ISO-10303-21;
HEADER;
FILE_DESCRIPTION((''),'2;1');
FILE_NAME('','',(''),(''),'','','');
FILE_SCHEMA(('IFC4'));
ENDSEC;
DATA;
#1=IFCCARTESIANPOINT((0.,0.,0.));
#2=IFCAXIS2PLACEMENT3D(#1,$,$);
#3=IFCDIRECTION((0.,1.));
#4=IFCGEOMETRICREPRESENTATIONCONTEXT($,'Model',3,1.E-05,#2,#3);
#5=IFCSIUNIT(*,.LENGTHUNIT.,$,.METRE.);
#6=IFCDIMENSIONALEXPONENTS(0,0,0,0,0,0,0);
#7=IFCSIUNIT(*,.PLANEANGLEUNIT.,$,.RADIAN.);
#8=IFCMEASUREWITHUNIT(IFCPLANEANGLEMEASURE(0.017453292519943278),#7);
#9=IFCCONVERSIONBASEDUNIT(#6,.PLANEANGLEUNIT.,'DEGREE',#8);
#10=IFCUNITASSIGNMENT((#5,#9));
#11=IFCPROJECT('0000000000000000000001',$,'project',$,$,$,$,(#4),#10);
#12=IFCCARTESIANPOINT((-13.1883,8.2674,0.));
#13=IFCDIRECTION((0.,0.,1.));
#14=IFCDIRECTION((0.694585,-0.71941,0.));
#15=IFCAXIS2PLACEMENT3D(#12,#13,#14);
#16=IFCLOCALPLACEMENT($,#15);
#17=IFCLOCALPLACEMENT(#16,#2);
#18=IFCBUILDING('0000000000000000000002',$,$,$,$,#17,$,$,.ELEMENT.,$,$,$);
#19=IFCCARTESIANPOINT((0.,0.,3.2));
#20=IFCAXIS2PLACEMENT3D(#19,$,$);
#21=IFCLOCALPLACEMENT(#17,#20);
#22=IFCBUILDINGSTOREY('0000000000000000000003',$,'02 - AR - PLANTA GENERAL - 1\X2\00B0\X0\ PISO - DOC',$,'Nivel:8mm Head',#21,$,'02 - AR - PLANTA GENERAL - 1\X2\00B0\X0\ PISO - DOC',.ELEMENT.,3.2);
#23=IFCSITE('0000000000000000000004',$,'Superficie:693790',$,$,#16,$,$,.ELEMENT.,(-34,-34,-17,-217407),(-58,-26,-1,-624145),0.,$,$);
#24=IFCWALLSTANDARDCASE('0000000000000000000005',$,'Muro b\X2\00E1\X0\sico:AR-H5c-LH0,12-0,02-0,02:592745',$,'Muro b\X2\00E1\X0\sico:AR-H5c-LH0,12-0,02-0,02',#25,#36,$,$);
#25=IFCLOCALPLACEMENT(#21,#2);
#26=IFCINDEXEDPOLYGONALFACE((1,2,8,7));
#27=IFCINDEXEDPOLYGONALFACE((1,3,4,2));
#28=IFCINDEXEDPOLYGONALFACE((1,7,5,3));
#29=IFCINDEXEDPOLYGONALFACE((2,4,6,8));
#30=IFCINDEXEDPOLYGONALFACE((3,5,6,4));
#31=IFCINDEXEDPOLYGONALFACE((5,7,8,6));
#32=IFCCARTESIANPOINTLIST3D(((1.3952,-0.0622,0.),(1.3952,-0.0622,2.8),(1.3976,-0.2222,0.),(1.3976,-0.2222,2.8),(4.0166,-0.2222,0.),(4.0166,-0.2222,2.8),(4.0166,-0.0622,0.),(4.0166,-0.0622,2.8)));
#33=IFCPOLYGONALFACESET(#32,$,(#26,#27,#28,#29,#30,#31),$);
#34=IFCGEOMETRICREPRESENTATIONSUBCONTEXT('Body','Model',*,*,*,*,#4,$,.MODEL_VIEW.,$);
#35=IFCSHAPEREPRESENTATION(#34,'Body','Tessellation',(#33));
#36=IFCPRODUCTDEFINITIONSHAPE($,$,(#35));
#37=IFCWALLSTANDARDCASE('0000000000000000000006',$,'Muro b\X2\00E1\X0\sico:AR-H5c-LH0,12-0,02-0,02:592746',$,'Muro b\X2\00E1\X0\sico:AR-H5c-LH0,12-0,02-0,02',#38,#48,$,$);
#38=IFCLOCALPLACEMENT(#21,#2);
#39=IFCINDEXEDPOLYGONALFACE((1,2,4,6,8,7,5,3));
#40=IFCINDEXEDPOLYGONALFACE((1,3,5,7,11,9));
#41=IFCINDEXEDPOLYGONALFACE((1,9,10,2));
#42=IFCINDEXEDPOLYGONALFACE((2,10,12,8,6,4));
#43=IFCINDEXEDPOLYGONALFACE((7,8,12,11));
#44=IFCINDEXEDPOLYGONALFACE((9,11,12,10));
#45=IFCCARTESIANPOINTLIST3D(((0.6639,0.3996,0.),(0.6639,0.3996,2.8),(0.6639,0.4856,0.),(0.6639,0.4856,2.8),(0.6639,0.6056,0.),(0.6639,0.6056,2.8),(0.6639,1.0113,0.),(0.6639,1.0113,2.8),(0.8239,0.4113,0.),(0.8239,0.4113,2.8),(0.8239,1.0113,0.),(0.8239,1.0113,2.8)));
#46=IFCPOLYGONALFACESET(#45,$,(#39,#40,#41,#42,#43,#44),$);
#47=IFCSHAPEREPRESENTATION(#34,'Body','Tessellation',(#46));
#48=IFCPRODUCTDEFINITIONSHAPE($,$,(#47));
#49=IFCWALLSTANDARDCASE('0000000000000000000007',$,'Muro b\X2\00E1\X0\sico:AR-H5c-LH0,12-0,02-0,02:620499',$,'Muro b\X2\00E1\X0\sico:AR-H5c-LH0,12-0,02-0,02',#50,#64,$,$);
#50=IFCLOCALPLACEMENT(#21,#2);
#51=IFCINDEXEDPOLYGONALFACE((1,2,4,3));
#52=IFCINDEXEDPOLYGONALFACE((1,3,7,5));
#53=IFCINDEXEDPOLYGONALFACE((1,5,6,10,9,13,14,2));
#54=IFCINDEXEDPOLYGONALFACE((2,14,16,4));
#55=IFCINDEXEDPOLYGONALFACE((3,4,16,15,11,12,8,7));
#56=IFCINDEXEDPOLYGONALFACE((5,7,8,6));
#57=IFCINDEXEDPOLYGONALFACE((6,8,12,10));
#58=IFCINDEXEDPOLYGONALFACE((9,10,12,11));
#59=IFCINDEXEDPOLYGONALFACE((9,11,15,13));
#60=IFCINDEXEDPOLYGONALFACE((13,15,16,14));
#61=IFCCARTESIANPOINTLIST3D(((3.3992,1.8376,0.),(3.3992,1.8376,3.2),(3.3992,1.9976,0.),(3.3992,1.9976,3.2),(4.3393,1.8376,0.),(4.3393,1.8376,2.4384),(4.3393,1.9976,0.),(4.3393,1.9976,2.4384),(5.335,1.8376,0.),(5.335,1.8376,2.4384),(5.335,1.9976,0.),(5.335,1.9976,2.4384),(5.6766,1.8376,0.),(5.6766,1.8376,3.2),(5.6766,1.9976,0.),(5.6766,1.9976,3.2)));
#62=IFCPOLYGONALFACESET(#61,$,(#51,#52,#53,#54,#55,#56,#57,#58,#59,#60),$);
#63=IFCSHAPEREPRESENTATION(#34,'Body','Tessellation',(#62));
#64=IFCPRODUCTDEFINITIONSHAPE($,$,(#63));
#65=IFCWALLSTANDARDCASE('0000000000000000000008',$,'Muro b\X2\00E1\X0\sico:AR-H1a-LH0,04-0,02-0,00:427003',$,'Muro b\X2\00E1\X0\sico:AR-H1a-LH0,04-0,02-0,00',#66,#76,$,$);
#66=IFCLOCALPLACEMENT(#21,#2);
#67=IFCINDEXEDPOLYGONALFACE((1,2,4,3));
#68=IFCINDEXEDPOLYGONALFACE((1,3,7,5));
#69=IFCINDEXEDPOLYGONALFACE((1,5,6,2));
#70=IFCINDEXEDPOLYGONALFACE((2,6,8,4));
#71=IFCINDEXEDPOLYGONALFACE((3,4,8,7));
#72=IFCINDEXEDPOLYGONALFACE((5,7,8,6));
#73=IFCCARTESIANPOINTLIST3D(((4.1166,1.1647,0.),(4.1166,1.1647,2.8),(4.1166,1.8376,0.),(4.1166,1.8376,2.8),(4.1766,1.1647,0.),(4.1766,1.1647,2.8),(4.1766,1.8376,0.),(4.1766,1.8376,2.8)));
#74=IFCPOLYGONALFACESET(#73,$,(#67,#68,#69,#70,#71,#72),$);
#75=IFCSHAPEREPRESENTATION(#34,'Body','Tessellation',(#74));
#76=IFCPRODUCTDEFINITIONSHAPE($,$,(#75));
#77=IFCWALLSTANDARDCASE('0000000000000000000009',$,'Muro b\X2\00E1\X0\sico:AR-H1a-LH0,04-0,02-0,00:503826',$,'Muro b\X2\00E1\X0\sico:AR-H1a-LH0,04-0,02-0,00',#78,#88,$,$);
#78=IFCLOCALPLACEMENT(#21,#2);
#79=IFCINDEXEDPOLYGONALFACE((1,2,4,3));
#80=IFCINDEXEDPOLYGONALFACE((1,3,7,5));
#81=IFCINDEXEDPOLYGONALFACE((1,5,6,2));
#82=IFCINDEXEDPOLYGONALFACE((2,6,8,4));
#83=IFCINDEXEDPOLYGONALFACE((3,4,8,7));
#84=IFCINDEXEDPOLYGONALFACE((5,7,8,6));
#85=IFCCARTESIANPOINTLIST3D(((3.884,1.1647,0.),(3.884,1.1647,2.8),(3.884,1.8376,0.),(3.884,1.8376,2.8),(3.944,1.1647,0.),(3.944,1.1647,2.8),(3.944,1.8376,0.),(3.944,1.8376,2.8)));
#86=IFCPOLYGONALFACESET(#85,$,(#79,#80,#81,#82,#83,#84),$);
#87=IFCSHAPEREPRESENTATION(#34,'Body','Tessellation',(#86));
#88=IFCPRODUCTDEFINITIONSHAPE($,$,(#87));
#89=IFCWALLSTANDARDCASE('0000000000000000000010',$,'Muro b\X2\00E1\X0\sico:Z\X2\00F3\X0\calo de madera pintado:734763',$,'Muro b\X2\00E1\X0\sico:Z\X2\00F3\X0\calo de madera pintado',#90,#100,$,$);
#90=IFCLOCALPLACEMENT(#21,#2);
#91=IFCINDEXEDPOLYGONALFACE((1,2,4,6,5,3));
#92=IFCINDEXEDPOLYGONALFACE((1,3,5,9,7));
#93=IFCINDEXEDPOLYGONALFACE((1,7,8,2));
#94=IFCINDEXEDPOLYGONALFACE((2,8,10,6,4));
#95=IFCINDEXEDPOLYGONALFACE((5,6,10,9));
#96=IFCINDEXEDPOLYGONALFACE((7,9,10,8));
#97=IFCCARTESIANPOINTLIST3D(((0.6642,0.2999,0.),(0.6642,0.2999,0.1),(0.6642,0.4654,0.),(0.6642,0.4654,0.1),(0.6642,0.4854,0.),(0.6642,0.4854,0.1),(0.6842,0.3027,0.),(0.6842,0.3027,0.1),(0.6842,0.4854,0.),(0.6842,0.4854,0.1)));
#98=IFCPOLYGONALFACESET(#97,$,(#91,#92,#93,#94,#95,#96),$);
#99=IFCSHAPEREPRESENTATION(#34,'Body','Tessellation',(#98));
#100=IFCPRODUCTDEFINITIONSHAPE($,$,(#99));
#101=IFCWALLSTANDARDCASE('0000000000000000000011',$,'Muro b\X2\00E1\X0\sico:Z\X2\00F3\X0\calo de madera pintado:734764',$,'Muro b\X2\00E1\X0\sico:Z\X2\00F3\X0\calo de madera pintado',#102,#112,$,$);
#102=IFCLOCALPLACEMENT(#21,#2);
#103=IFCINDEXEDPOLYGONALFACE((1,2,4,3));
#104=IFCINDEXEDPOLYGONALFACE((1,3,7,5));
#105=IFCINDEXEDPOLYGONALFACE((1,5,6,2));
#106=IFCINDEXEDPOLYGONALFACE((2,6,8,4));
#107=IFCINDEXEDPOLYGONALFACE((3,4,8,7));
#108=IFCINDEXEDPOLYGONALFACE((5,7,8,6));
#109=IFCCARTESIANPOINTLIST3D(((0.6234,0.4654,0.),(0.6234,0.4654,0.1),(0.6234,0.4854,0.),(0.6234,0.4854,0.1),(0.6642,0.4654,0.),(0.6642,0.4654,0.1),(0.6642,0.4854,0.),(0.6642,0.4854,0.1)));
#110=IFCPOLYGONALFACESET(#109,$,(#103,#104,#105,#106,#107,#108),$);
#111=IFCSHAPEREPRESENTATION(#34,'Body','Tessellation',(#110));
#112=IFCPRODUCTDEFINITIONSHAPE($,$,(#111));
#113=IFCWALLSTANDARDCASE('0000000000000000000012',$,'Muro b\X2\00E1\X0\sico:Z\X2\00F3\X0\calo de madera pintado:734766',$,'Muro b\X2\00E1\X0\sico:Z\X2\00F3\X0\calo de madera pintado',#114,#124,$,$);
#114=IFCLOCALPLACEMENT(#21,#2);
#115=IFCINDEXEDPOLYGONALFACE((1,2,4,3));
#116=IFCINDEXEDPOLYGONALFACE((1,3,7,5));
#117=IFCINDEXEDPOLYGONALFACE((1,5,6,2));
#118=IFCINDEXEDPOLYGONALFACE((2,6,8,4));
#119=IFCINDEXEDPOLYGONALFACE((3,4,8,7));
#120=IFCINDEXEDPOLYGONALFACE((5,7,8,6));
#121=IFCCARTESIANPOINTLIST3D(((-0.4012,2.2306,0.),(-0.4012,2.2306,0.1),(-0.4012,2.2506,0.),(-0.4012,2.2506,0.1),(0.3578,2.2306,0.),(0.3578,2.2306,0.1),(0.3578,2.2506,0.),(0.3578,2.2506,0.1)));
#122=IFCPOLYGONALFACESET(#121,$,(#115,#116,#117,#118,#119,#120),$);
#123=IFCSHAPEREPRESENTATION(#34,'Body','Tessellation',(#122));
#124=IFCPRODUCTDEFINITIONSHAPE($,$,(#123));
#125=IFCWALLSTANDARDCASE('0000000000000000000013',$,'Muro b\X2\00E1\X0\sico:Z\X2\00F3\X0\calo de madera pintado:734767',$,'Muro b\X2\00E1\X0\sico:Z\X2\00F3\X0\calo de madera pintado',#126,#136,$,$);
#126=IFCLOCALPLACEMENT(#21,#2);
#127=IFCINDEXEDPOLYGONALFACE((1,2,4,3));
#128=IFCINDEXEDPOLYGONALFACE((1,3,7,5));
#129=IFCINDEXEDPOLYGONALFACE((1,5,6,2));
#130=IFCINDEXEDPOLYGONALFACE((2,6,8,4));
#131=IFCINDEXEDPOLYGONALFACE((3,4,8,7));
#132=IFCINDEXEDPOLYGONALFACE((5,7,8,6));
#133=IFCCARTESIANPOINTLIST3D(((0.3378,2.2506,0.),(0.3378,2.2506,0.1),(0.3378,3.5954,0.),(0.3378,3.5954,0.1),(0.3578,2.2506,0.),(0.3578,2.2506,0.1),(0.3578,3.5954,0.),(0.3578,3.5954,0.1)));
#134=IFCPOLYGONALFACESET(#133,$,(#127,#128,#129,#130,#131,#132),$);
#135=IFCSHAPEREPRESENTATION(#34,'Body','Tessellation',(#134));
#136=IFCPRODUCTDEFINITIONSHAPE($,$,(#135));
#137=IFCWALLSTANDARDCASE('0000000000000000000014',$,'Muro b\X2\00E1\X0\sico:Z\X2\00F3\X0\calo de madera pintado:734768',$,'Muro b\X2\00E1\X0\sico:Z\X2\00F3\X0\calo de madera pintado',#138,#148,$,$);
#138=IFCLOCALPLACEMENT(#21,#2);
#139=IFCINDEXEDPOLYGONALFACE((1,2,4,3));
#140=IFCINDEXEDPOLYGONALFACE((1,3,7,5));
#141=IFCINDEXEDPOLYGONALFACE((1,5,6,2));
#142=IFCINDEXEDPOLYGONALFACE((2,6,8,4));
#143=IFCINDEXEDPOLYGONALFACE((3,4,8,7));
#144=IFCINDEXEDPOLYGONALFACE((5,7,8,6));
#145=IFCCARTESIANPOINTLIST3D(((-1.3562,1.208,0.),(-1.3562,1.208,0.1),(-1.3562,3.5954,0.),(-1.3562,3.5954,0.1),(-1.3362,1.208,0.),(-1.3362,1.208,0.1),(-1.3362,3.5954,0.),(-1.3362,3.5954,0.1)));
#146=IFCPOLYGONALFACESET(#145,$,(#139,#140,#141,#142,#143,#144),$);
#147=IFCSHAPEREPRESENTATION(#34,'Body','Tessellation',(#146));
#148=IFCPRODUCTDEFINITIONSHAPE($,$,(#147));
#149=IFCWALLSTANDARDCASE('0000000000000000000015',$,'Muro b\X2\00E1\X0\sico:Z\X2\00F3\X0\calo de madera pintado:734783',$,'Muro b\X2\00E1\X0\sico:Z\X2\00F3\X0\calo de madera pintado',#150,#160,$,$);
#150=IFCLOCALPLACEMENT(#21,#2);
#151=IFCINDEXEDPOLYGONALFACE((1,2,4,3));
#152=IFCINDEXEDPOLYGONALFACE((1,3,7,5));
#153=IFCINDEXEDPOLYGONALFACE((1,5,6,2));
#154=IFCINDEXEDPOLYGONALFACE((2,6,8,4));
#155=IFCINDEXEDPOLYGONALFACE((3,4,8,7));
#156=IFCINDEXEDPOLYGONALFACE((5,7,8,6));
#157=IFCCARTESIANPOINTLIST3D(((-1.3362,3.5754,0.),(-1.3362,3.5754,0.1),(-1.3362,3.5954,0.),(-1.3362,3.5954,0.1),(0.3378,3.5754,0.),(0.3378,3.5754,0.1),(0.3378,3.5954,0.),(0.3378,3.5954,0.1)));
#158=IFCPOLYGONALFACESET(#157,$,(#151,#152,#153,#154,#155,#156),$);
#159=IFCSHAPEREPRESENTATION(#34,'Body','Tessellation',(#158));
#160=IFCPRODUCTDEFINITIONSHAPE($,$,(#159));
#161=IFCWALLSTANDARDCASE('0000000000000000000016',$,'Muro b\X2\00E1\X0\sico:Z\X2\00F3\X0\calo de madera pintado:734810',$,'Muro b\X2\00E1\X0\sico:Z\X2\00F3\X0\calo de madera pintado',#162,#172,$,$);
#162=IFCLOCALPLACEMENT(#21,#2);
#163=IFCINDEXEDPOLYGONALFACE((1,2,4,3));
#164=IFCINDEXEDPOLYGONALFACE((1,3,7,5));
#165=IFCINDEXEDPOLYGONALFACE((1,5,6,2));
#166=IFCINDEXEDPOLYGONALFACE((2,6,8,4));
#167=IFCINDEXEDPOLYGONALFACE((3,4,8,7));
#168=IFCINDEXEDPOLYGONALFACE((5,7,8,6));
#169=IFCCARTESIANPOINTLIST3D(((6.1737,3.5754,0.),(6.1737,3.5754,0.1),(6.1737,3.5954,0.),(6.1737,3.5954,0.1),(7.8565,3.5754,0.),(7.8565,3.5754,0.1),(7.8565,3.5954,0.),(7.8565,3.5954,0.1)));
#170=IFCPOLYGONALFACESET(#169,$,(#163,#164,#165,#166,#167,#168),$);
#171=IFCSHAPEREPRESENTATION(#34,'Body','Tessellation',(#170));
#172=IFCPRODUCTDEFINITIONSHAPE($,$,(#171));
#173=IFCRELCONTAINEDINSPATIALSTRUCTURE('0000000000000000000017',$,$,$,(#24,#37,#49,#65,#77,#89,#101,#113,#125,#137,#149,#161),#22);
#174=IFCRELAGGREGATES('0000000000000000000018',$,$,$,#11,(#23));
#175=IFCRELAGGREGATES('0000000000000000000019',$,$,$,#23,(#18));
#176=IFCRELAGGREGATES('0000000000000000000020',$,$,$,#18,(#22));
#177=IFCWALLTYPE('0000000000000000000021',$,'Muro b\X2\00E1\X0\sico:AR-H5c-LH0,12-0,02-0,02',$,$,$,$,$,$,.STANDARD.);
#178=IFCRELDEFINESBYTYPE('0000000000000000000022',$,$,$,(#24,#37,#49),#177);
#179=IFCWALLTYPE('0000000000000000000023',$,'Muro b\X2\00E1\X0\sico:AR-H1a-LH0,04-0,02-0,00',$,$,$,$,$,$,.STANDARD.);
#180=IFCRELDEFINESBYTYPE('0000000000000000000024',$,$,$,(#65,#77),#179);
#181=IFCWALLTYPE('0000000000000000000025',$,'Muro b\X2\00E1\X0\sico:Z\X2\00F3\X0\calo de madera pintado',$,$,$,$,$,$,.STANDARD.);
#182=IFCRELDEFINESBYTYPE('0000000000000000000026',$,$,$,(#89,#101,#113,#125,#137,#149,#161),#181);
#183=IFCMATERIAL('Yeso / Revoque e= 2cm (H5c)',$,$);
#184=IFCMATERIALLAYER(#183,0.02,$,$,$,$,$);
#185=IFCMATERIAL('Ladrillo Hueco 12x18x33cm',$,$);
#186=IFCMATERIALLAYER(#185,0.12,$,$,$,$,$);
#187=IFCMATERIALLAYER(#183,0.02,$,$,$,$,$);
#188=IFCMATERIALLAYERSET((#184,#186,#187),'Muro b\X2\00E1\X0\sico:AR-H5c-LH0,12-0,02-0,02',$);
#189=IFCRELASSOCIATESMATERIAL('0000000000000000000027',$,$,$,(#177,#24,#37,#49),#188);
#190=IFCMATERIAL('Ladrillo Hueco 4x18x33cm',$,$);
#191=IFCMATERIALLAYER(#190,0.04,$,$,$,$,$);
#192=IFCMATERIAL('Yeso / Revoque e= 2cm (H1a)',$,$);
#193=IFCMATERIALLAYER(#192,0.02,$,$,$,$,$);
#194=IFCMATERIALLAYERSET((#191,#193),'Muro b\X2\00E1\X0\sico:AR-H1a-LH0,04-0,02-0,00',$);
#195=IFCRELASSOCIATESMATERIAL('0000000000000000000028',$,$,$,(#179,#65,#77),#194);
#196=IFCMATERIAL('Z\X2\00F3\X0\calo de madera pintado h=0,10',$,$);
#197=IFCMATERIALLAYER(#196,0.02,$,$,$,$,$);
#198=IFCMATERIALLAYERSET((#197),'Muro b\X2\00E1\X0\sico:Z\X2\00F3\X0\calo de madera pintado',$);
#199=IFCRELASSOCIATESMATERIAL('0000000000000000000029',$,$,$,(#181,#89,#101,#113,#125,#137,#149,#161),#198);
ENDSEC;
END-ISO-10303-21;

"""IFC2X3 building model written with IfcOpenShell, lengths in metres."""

from ifc_helpers import new_model, entity, si_unit, converted_unit, direction, frame, frame_2d, origin, place, context, subcontext, project, spatial, polyline, rectangle, outline, extrude, material, layer, layer_set, layer_usage, type_object, element, save


model = new_model("IFC2X3")

# Units and contexts
model_context = context("Model", 3, precision=1e-05, world=origin(), true_north=direction((0.0, 1.0)))
body_context = subcontext(model_context, "Body", "Model", "MODEL_VIEW")
ifc_project = project(units=[si_unit("LENGTHUNIT", "METRE"), converted_unit("PLANEANGLEUNIT", "DEGREE", entity("IfcPlaneAngleMeasure", 0.017453292519943278), si_unit("PLANEANGLEUNIT", "RADIAN"), dimensions=[0, 0, 0, 0, 0, 0, 0])], contexts=[model_context])

# Site, building, storey
site_placement = place(None, frame((-13.1883, 8.2674, 0.0), z_axis=(0.0, 0.0, 1.0), x_axis=(0.694585, -0.71941, 0.0)))
site = spatial("IfcSite", under=ifc_project, at=site_placement, Name="Superficie:693790", CompositionType="ELEMENT", RefLatitude=(-34, -34, -17, -217407), RefLongitude=(-58, -26, -1, -624145), RefElevation=0.0)
building_placement = place(site_placement, origin())
building = spatial("IfcBuilding", under=site, at=building_placement, CompositionType="ELEMENT")
storey_placement = place(building_placement, frame((0.0, 0.0, 3.2)))
storey = spatial("IfcBuildingStorey", under=building, at=storey_placement, Name="02 - AR - PLANTA GENERAL - 1° PISO - DOC", ObjectType="Nivel:8mm Head", LongName="02 - AR - PLANTA GENERAL - 1° PISO - DOC", CompositionType="ELEMENT", Elevation=3.2)

# Walls
ifc_material_1 = material(Name="Yeso / Revoque e= 2cm (H5c)")
ifc_layer_1 = layer(ifc_material_1, 0.02)
ifc_material_2 = material(Name="Ladrillo Hueco 12x18x33cm")
ifc_layer_2 = layer(ifc_material_2, 0.12)
ifc_layer_3 = layer(ifc_material_1, 0.02)
ifc_layer_set_1 = layer_set([ifc_layer_1, ifc_layer_2, ifc_layer_3], Name="Muro básico:AR-H5c-LH0,12-0,02-0,02")
ifc_layer_usage_1 = layer_usage(ifc_layer_set_1, "AXIS2", "NEGATIVE", 0.08)
wall_type_1 = type_object("IfcWallType", Name="Muro básico:AR-H5c-LH0,12-0,02-0,02", PredefinedType="STANDARD", material=ifc_layer_set_1)
wall_1_placement = place(storey_placement, frame((1.3952, -0.1422, 0.0)))
element("IfcWallStandardCase", 1, at=wall_1_placement, inside=storey, type_object=wall_type_1, material=ifc_layer_usage_1, Name="Muro básico:AR-H5c-LH0,12-0,02-0,02:592745", ObjectType="Muro básico:AR-H5c-LH0,12-0,02-0,02", context=body_context, shape_type="SweptSolid", body=[
    extrude(outline(polyline([(2.6214, -0.08), (2.6214, 0.08), (0.0, 0.08), (0.0024, -0.08), (2.6214, -0.08)])), origin(), (0.0, 0.0, 1.0), 2.8),
])
ifc_layer_usage_2 = layer_usage(ifc_layer_set_1, "AXIS2", "NEGATIVE", 0.08)
wall_2_placement = place(storey_placement, frame((0.7439, 0.3996, 0.0), z_axis=(0.0, 0.0, 1.0), x_axis=(0.0, 1.0, 0.0)))
element("IfcWallStandardCase", 2, at=wall_2_placement, inside=storey, type_object=wall_type_1, material=ifc_layer_usage_2, Name="Muro básico:AR-H5c-LH0,12-0,02-0,02:592746", ObjectType="Muro básico:AR-H5c-LH0,12-0,02-0,02", context=body_context, shape_type="SweptSolid", body=[
    extrude(outline(polyline([(0.6117, -0.08), (0.6117, 0.08), (0.2059, 0.08), (0.0859, 0.08), (0.0, 0.08), (0.0117, -0.08), (0.6117, -0.08)])), origin(), (0.0, 0.0, 1.0), 2.8),
])

# Wall, opening
ifc_layer_usage_3 = layer_usage(ifc_layer_set_1, "AXIS2", "NEGATIVE", 0.08)
wall_3_placement = place(storey_placement, frame((5.6766, 1.9176, 0.0), z_axis=(0.0, 0.0, 1.0), x_axis=(-1.0, 0.0, 0.0)))
wall_3 = element("IfcWallStandardCase", 3, at=wall_3_placement, inside=storey, type_object=wall_type_1, material=ifc_layer_usage_3, Name="Muro básico:AR-H5c-LH0,12-0,02-0,02:620499", ObjectType="Muro básico:AR-H5c-LH0,12-0,02-0,02", context=body_context, shape_type="SweptSolid", body=[
    extrude(rectangle(XDim=2.2775, YDim=0.16, at=frame_2d((1.1387, 0.0), x_axis=(1.0, 0.0))), origin(), (0.0, 0.0, 1.0), 3.2),
])
opening_1_placement = place(wall_3_placement, origin())
element("IfcOpeningElement", 4, at=opening_1_placement, cuts=wall_3, ObjectType="Opening", context=body_context, shape_type="SweptSolid", body=[
    extrude(rectangle(XDim=2.4384, YDim=0.9958, at=frame_2d((0.0, 0.0), x_axis=(1.0, 0.0))), frame((0.8395, -0.08, 1.2192), z_axis=(0.0, 1.0, 0.0), x_axis=(0.0, 0.0, -1.0)), (0.0, 0.0, 1.0), 0.16),
])

# Walls
ifc_material_3 = material(Name="Ladrillo Hueco 4x18x33cm")
ifc_layer_4 = layer(ifc_material_3, 0.04)
ifc_material_4 = material(Name="Yeso / Revoque e= 2cm (H1a)")
ifc_layer_5 = layer(ifc_material_4, 0.02)
ifc_layer_set_2 = layer_set([ifc_layer_4, ifc_layer_5], Name="Muro básico:AR-H1a-LH0,04-0,02-0,00")
ifc_layer_usage_4 = layer_usage(ifc_layer_set_2, "AXIS2", "POSITIVE", -0.03)
wall_type_2 = type_object("IfcWallType", Name="Muro básico:AR-H1a-LH0,04-0,02-0,00", PredefinedType="STANDARD", material=ifc_layer_set_2)
wall_4_placement = place(storey_placement, frame((4.1466, 1.8376, 0.0), z_axis=(0.0, 0.0, 1.0), x_axis=(0.0, -1.0, 0.0)))
element("IfcWallStandardCase", 5, at=wall_4_placement, inside=storey, type_object=wall_type_2, material=ifc_layer_usage_4, Name="Muro básico:AR-H1a-LH0,04-0,02-0,00:427003", ObjectType="Muro básico:AR-H1a-LH0,04-0,02-0,00", context=body_context, shape_type="SweptSolid", body=[
    extrude(rectangle(XDim=0.673, YDim=0.06, at=frame_2d((0.3365, 0.0), x_axis=(-1.0, 0.0))), origin(), (0.0, 0.0, 1.0), 2.8),
])
ifc_layer_usage_5 = layer_usage(ifc_layer_set_2, "AXIS2", "POSITIVE", -0.03)
wall_5_placement = place(storey_placement, frame((3.914, 1.8376, 0.0), z_axis=(0.0, 0.0, 1.0), x_axis=(0.0, -1.0, 0.0)))
element("IfcWallStandardCase", 6, at=wall_5_placement, inside=storey, type_object=wall_type_2, material=ifc_layer_usage_5, Name="Muro básico:AR-H1a-LH0,04-0,02-0,00:503826", ObjectType="Muro básico:AR-H1a-LH0,04-0,02-0,00", context=body_context, shape_type="SweptSolid", body=[
    extrude(rectangle(XDim=0.673, YDim=0.06, at=frame_2d((0.3365, 0.0), x_axis=(-1.0, 0.0))), origin(), (0.0, 0.0, 1.0), 2.8),
])
ifc_material_5 = material(Name="Zócalo de madera pintado h=0,10")
ifc_layer_6 = layer(ifc_material_5, 0.02)
ifc_layer_set_3 = layer_set([ifc_layer_6], Name="Muro básico:Zócalo de madera pintado")
wall_type_3 = type_object("IfcWallType", Name="Muro básico:Zócalo de madera pintado", PredefinedType="STANDARD", material=ifc_layer_set_3)
ifc_layer_usage_6 = layer_usage(ifc_layer_set_3, "AXIS2", "NEGATIVE", 0.01)
wall_6_placement = place(storey_placement, frame((0.6742, 0.2999, 0.0), z_axis=(0.0, 0.0, 1.0), x_axis=(0.0, 1.0, 0.0)))
element("IfcWallStandardCase", 7, at=wall_6_placement, inside=storey, type_object=wall_type_3, material=ifc_layer_usage_6, Name="Muro básico:Zócalo de madera pintado:734763", ObjectType="Muro básico:Zócalo de madera pintado", context=body_context, shape_type="SweptSolid", body=[
    extrude(outline(polyline([(0.1855, -0.01), (0.1855, 0.01), (0.1655, 0.01), (0.0, 0.01), (0.0027, -0.01), (0.1855, -0.01)])), origin(), (0.0, 0.0, 1.0), 0.1),
])
ifc_layer_usage_7 = layer_usage(ifc_layer_set_3, "AXIS2", "NEGATIVE", 0.01)
wall_7_placement = place(storey_placement, frame((0.6642, 0.4754, 0.0), z_axis=(0.0, 0.0, 1.0), x_axis=(-1.0, 0.0, 0.0)))
element("IfcWallStandardCase", 8, at=wall_7_placement, inside=storey, type_object=wall_type_3, material=ifc_layer_usage_7, Name="Muro básico:Zócalo de madera pintado:734764", ObjectType="Muro básico:Zócalo de madera pintado", context=body_context, shape_type="SweptSolid", body=[
    extrude(rectangle(XDim=0.0408, YDim=0.02, at=frame_2d((0.0204, 0.0), x_axis=(-1.0, 0.0))), origin(), (0.0, 0.0, 1.0), 0.1),
])
ifc_layer_usage_8 = layer_usage(ifc_layer_set_3, "AXIS2", "NEGATIVE", 0.01)
wall_8_placement = place(storey_placement, frame((-0.4012, 2.2406, 0.0)))
element("IfcWallStandardCase", 9, at=wall_8_placement, inside=storey, type_object=wall_type_3, material=ifc_layer_usage_8, Name="Muro básico:Zócalo de madera pintado:734766", ObjectType="Muro básico:Zócalo de madera pintado", context=body_context, shape_type="SweptSolid", body=[
    extrude(rectangle(XDim=0.759, YDim=0.02, at=frame_2d((0.3795, 0.0), x_axis=(-1.0, 0.0))), origin(), (0.0, 0.0, 1.0), 0.1),
])
ifc_layer_usage_9 = layer_usage(ifc_layer_set_3, "AXIS2", "NEGATIVE", 0.01)
wall_9_placement = place(storey_placement, frame((0.3478, 2.2506, 0.0), z_axis=(0.0, 0.0, 1.0), x_axis=(0.0, 1.0, 0.0)))
element("IfcWallStandardCase", 10, at=wall_9_placement, inside=storey, type_object=wall_type_3, material=ifc_layer_usage_9, Name="Muro básico:Zócalo de madera pintado:734767", ObjectType="Muro básico:Zócalo de madera pintado", context=body_context, shape_type="SweptSolid", body=[
    extrude(rectangle(XDim=1.3448, YDim=0.02, at=frame_2d((0.6724, 0.0), x_axis=(-1.0, 0.0))), origin(), (0.0, 0.0, 1.0), 0.1),
])
ifc_layer_usage_10 = layer_usage(ifc_layer_set_3, "AXIS2", "NEGATIVE", 0.01)
wall_10_placement = place(storey_placement, frame((-1.3462, 3.5954, 0.0), z_axis=(0.0, 0.0, 1.0), x_axis=(0.0, -1.0, 0.0)))
element("IfcWallStandardCase", 11, at=wall_10_placement, inside=storey, type_object=wall_type_3, material=ifc_layer_usage_10, Name="Muro básico:Zócalo de madera pintado:734768", ObjectType="Muro básico:Zócalo de madera pintado", context=body_context, shape_type="SweptSolid", body=[
    extrude(rectangle(XDim=2.3874, YDim=0.02, at=frame_2d((1.1937, 0.0), x_axis=(-1.0, 0.0))), origin(), (0.0, 0.0, 1.0), 0.1),
])
ifc_layer_usage_11 = layer_usage(ifc_layer_set_3, "AXIS2", "NEGATIVE", 0.01)
wall_11_placement = place(storey_placement, frame((0.3378, 3.5854, 0.0), z_axis=(0.0, 0.0, 1.0), x_axis=(-1.0, 0.0, 0.0)))
element("IfcWallStandardCase", 12, at=wall_11_placement, inside=storey, type_object=wall_type_3, material=ifc_layer_usage_11, Name="Muro básico:Zócalo de madera pintado:734783", ObjectType="Muro básico:Zócalo de madera pintado", context=body_context, shape_type="SweptSolid", body=[
    extrude(rectangle(XDim=1.674, YDim=0.02, at=frame_2d((0.837, 0.0), x_axis=(-1.0, 0.0))), origin(), (0.0, 0.0, 1.0), 0.1),
])
ifc_layer_usage_12 = layer_usage(ifc_layer_set_3, "AXIS2", "NEGATIVE", 0.01)
wall_12_placement = place(storey_placement, frame((6.1737, 3.5854, 0.0)))
element("IfcWallStandardCase", 13, at=wall_12_placement, inside=storey, type_object=wall_type_3, material=ifc_layer_usage_12, Name="Muro básico:Zócalo de madera pintado:734810", ObjectType="Muro básico:Zócalo de madera pintado", context=body_context, shape_type="SweptSolid", body=[
    extrude(rectangle(XDim=1.6828, YDim=0.02, at=frame_2d((0.8414, 0.0), x_axis=(-1.0, 0.0))), origin(), (0.0, 0.0, 1.0), 0.1),
])

save(model, "model.ifc")
